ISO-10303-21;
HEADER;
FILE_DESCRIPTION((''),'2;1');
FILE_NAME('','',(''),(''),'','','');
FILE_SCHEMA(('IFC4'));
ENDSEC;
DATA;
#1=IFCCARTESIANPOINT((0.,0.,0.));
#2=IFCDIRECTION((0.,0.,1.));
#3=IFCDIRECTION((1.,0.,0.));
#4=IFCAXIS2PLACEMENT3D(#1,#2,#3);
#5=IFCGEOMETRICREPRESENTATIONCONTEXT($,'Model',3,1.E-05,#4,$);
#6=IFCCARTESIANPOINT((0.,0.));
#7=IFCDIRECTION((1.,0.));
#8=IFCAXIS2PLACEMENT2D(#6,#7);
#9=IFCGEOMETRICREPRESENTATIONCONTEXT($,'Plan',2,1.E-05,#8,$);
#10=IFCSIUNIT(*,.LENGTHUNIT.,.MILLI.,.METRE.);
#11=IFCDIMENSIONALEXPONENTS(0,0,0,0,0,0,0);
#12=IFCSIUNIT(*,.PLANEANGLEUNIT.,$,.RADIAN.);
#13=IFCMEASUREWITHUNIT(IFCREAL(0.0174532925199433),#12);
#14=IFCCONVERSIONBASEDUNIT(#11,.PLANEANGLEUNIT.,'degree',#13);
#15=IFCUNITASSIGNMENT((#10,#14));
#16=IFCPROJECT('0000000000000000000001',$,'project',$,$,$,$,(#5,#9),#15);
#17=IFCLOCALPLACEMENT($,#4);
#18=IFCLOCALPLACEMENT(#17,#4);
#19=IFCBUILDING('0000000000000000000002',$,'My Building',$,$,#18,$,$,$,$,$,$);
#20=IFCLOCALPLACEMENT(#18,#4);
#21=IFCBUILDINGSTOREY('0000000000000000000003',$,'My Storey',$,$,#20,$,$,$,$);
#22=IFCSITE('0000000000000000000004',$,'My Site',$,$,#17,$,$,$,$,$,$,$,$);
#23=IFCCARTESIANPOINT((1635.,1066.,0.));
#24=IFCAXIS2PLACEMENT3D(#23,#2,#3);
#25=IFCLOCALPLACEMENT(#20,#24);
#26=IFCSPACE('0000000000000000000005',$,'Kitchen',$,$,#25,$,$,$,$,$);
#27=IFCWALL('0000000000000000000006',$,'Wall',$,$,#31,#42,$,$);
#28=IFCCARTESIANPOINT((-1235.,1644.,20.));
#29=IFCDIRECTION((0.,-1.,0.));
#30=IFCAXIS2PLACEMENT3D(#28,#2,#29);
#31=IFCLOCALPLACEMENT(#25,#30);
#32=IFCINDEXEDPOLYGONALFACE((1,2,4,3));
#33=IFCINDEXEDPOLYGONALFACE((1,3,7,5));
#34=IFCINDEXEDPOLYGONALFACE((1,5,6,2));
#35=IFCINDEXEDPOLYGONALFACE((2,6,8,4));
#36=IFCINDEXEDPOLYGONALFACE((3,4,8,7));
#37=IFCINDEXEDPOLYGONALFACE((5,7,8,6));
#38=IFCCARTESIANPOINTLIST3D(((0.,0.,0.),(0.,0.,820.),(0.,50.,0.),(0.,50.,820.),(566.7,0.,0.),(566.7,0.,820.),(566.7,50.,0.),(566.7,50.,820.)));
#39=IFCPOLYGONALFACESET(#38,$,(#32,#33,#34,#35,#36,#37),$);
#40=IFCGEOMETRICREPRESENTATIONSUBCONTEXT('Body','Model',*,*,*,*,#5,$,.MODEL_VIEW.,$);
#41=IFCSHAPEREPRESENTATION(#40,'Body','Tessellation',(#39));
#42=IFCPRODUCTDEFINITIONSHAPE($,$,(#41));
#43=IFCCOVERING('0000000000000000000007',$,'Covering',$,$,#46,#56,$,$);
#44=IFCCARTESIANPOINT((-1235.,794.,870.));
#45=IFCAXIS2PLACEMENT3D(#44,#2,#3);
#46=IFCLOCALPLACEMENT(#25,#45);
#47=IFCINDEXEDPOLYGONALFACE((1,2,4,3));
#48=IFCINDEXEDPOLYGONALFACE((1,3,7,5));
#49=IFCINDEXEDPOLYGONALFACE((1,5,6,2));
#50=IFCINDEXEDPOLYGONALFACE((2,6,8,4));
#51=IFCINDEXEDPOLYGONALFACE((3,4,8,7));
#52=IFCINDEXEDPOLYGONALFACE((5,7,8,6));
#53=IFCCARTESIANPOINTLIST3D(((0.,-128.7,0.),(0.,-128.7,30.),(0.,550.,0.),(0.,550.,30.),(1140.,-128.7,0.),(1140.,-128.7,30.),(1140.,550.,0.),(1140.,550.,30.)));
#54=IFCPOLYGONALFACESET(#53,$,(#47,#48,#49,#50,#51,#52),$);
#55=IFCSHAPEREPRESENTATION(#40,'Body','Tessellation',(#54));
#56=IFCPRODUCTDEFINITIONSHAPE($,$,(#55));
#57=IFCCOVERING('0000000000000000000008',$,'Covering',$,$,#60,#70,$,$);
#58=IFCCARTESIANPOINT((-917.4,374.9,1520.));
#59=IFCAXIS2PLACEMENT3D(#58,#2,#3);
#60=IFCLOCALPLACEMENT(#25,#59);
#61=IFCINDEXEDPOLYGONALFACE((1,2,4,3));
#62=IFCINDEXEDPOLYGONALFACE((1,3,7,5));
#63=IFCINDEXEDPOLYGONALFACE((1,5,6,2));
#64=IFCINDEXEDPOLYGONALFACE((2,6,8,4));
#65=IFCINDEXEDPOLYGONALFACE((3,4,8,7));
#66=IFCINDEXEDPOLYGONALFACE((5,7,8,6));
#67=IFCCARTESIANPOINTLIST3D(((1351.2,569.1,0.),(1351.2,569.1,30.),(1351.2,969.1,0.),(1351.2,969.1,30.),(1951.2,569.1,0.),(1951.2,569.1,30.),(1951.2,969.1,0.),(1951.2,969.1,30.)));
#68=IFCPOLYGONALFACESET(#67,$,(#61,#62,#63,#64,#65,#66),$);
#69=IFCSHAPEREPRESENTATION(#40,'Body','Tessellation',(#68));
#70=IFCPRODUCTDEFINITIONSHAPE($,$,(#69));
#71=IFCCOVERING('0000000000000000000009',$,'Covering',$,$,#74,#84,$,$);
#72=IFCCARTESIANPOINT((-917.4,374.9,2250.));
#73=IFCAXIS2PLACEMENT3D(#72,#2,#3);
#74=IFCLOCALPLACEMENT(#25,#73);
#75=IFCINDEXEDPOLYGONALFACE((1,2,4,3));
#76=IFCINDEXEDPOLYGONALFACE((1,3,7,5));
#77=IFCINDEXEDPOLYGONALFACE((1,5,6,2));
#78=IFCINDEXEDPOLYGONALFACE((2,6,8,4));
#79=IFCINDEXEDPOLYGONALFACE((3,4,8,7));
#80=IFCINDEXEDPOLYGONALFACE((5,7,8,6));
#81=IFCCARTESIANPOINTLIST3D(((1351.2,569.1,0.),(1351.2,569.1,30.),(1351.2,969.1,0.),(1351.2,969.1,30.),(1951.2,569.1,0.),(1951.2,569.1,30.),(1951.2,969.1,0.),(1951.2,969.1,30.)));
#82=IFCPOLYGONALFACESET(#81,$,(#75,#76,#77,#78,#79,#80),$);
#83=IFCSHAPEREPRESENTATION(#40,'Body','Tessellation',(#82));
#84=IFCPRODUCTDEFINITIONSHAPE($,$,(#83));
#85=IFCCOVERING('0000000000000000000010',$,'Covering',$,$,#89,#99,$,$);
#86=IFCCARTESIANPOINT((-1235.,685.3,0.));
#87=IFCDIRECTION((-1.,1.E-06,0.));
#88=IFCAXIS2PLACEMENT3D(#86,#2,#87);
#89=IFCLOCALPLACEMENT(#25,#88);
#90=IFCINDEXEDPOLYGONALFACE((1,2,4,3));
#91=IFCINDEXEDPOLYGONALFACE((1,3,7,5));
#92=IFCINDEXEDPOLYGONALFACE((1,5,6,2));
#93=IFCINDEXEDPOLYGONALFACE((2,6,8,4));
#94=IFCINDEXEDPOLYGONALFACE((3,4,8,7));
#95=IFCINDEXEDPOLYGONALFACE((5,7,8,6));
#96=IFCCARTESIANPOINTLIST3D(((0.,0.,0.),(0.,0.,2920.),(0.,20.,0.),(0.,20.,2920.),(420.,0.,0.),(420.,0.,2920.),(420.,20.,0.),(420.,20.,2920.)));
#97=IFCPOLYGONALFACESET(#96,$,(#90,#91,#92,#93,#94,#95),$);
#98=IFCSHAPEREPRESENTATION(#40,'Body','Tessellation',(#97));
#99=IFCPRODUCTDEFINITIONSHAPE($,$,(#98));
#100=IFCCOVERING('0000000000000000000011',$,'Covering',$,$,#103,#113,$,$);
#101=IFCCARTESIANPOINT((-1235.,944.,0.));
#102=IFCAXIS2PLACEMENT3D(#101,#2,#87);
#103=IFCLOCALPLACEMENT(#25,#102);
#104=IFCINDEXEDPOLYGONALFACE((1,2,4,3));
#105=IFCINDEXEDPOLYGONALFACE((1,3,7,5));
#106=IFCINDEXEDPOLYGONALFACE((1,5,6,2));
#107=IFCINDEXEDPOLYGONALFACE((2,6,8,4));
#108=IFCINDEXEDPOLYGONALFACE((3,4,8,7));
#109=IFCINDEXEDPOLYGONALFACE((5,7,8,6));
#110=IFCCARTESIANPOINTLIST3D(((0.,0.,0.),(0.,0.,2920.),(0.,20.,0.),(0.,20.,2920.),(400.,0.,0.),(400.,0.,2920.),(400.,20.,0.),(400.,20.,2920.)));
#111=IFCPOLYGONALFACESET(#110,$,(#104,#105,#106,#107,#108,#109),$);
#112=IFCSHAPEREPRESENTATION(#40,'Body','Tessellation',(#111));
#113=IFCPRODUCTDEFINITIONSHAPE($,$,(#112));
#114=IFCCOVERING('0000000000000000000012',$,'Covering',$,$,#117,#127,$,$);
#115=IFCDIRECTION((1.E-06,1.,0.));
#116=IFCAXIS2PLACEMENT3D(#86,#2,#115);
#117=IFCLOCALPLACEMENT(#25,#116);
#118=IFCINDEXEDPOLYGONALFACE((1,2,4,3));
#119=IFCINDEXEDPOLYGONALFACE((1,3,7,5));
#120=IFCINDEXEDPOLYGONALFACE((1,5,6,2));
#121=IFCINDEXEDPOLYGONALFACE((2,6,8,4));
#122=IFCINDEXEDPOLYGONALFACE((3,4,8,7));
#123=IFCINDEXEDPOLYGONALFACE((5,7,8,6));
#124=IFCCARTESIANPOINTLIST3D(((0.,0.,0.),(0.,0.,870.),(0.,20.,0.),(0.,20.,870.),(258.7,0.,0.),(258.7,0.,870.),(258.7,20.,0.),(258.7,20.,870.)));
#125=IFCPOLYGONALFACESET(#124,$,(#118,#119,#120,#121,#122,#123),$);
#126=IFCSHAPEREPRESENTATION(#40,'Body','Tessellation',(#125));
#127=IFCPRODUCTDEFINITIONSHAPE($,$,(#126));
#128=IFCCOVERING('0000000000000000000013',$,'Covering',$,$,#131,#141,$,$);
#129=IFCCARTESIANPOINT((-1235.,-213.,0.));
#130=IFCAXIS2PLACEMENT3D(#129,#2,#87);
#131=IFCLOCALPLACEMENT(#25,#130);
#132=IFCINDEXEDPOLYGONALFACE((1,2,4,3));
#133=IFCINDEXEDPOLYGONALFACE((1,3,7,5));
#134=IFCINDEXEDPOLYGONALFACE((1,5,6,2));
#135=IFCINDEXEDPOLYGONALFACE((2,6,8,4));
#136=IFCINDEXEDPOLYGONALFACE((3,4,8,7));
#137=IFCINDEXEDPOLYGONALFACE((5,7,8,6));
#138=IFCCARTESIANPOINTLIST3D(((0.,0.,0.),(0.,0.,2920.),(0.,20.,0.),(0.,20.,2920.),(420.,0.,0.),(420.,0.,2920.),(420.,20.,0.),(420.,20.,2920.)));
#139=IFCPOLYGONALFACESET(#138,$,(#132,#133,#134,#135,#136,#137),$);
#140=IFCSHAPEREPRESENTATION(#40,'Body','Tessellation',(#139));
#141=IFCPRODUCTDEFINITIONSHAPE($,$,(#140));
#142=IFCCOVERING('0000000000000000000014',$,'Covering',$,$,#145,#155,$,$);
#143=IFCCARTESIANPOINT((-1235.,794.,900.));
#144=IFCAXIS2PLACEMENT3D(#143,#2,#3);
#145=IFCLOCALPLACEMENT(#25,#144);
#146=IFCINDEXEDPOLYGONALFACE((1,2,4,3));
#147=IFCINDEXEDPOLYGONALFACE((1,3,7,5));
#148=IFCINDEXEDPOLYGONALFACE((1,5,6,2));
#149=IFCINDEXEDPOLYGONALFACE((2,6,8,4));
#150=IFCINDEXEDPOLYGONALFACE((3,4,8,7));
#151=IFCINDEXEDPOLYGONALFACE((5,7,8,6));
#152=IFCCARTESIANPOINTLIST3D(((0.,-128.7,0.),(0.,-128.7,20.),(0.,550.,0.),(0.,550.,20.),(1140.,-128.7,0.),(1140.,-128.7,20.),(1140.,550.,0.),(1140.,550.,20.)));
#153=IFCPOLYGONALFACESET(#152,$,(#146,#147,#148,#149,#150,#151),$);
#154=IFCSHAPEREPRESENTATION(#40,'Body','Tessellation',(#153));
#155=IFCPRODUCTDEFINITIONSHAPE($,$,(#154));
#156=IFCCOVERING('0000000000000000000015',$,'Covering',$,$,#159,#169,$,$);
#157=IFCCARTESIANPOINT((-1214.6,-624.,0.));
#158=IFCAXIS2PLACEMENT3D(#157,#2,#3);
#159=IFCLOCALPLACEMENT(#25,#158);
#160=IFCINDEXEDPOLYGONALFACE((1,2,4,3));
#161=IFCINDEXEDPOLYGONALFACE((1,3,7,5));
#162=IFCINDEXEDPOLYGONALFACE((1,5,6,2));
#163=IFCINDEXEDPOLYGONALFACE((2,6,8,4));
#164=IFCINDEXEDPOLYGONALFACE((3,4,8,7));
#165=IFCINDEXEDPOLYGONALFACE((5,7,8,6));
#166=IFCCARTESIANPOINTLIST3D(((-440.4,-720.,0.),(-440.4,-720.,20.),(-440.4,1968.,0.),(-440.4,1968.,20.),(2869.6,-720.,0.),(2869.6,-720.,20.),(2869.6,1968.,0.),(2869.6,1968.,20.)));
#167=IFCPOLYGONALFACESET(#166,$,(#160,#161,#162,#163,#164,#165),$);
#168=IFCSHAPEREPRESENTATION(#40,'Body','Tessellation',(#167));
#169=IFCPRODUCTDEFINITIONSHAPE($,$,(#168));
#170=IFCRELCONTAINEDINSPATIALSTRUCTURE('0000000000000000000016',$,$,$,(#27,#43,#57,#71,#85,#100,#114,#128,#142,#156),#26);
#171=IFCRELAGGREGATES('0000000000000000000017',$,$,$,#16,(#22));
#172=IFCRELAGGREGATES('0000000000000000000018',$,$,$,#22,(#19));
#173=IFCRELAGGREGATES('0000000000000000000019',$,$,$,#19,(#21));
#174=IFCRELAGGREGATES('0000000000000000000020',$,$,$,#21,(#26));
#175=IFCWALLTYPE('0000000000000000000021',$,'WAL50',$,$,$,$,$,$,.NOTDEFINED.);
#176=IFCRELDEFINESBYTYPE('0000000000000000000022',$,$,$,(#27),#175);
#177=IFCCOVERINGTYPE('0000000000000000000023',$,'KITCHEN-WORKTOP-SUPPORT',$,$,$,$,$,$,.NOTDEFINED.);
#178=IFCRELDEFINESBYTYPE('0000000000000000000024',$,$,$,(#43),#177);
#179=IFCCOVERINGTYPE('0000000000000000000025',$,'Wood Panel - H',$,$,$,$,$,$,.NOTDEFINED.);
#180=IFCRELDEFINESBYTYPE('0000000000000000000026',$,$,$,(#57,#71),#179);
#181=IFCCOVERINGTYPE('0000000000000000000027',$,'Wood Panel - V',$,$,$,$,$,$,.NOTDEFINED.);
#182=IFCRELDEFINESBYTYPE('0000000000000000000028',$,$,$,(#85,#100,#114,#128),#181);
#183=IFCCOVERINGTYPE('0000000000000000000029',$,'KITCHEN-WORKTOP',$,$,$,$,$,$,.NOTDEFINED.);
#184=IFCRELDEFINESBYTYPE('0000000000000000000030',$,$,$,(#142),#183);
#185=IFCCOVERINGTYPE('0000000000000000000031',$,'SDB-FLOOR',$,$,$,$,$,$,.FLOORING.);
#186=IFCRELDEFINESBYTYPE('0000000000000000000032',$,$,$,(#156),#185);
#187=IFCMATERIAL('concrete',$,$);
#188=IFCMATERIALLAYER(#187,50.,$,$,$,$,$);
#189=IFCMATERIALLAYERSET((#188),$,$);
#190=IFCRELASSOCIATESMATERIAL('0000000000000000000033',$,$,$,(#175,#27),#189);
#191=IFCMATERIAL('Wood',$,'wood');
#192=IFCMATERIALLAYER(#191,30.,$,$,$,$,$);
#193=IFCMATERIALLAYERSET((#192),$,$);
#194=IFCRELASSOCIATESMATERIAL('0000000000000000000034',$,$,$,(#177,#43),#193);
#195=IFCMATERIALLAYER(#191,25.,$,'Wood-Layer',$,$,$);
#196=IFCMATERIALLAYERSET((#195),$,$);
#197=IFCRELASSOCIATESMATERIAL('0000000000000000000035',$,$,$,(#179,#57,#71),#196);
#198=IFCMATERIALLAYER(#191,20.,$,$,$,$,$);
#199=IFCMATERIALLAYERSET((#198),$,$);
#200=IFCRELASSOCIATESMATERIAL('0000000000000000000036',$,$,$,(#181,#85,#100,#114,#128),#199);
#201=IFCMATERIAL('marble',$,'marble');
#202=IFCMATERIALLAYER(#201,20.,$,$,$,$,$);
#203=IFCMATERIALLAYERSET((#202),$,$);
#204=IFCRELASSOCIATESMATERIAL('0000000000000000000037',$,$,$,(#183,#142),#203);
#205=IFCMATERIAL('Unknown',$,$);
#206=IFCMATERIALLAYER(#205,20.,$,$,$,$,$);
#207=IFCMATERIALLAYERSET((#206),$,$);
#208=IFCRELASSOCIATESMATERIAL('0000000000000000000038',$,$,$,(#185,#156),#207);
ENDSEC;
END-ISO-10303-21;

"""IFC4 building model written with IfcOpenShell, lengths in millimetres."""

from ifc_helpers import new_model, entity, si_unit, converted_unit, frame, origin_with_axes, origin_2d_with_axis, place, context, subcontext, project, spatial, line, indexed_curve, outline, extrude, clip, halfspace, material, layer, layer_set, layer_usage, type_object, element, save


model = new_model("IFC4")

# Units and contexts
model_context = context("Model", 3, precision=1e-05, world=origin_with_axes())
plan_context = context("Plan", 2, precision=1e-05, world=origin_2d_with_axis())
body_context = subcontext(model_context, "Body", "Model", "MODEL_VIEW")
ifc_project = project(units=[si_unit("LENGTHUNIT", "METRE", prefix="MILLI"), converted_unit("PLANEANGLEUNIT", "degree", entity("IfcReal", 0.0174532925199433), si_unit("PLANEANGLEUNIT", "RADIAN"), dimensions=[0, 0, 0, 0, 0, 0, 0])], contexts=[model_context, plan_context])

# Site, building, storey
site_placement = place(None, origin_with_axes())
site = spatial("IfcSite", under=ifc_project, at=site_placement, Name="My Site")
building_placement = place(site_placement, origin_with_axes())
building = spatial("IfcBuilding", under=site, at=building_placement, Name="My Building")
storey_placement = place(building_placement, origin_with_axes())
storey = spatial("IfcBuildingStorey", under=building, at=storey_placement, Name="My Storey")

# Shared definitions
ifc_material_1 = material(Name="concrete")

# Shared definitions
space_1_placement = place(storey_placement, frame((1635.0, 1066.0, 0.0), z_axis=(0.0, 0.0, 1.0), x_axis=(1.0, 0.0, 0.0)))
space_1 = spatial("IfcSpace", under=storey, at=space_1_placement, Name="Kitchen")

# Wall
ifc_layer_1 = layer(ifc_material_1, 50.0)
ifc_layer_set_1 = layer_set([ifc_layer_1])
ifc_layer_usage_1 = layer_usage(ifc_layer_set_1, "AXIS2", "POSITIVE", 0.0)
wall_type_1 = type_object("IfcWallType", Name="WAL50", PredefinedType="NOTDEFINED", material=ifc_layer_set_1)
wall_1_placement = place(space_1_placement, frame((-1235.0, 1644.0, 20.0), z_axis=(0.0, 0.0, 1.0), x_axis=(0.0, -1.0, 0.0)))
element("IfcWall", 1, at=wall_1_placement, inside=space_1, type_object=wall_type_1, material=ifc_layer_usage_1, Name="Wall", context=body_context, shape_type="Clipping", body=[
    clip(extrude(outline(indexed_curve([(0.0, 0.0), (0.0, 50.0), (566.7, 50.0), (566.7, 0.0), (0.0, 0.0)], self_intersect=False)), origin_with_axes(), (0.0, 0.0, 1.0), 820.0), halfspace(frame((0.0, 0.0, 820.0), z_axis=(0.0, 0.0, 1.0), x_axis=(-1.0, 0.0, 0.0)), False)),
])

# Coverings
ifc_material_2 = material(Name="marble", Category="marble")
ifc_material_3 = material(Name="Wood", Category="wood")
ifc_layer_2 = layer(ifc_material_3, 30.0)
ifc_layer_set_2 = layer_set([ifc_layer_2])
ifc_layer_usage_2 = layer_usage(ifc_layer_set_2, "AXIS3", "POSITIVE", 0.0)
covering_type_1 = type_object("IfcCoveringType", Name="KITCHEN-WORKTOP-SUPPORT", PredefinedType="NOTDEFINED", material=ifc_layer_set_2)
covering_1_placement = place(space_1_placement, frame((-1235.0, 794.0, 870.0), z_axis=(0.0, 0.0, 1.0), x_axis=(1.0, 0.0, 0.0)))
element("IfcCovering", 2, at=covering_1_placement, inside=space_1, type_object=covering_type_1, material=ifc_layer_usage_2, Name="Covering", context=body_context, shape_type="SweptSolid", body=[
    extrude(outline(indexed_curve([(1140.0, -128.7), (1140.0, 550.0), (0.0, 550.0), (0.0, -128.7)], segments=[line(4, 1), line(1, 2), line(2, 3), line(3, 4)], self_intersect=False)), None, (0.0, 0.0, 1.0), 30.0),
])
ifc_layer_3 = layer(ifc_material_3, 25.0, Name="Wood-Layer")
ifc_layer_set_3 = layer_set([ifc_layer_3])
ifc_layer_usage_3 = layer_usage(ifc_layer_set_3, "AXIS3", "POSITIVE", 0.0)
covering_type_2 = type_object("IfcCoveringType", Name="Wood Panel - H", PredefinedType="NOTDEFINED", material=ifc_layer_set_3)
covering_2_placement = place(space_1_placement, frame((-917.4, 374.9, 1520.0), z_axis=(0.0, 0.0, 1.0), x_axis=(1.0, 0.0, 0.0)))
element("IfcCovering", 3, at=covering_2_placement, inside=space_1, type_object=covering_type_2, material=ifc_layer_usage_3, Name="Covering", context=body_context, shape_type="SweptSolid", body=[
    extrude(outline(indexed_curve([(1351.2, 569.1), (1951.2, 569.1), (1951.2, 969.1), (1351.2, 969.1)], segments=[line(4, 1), line(1, 2), line(2, 3), line(3, 4)], self_intersect=False)), None, (0.0, 0.0, 1.0), 30.0),
])
ifc_layer_usage_4 = layer_usage(ifc_layer_set_3, "AXIS3", "POSITIVE", 0.0)
covering_3_placement = place(space_1_placement, frame((-917.4, 374.9, 2250.0), z_axis=(0.0, 0.0, 1.0), x_axis=(1.0, 0.0, 0.0)))
element("IfcCovering", 4, at=covering_3_placement, inside=space_1, type_object=covering_type_2, material=ifc_layer_usage_4, Name="Covering", context=body_context, shape_type="SweptSolid", body=[
    extrude(outline(indexed_curve([(1351.2, 569.1), (1951.2, 569.1), (1951.2, 969.1), (1351.2, 969.1)], segments=[line(3, 2), line(2, 1), line(1, 4), line(4, 3)], self_intersect=False)), None, (0.0, 0.0, 1.0), 30.0),
])
ifc_layer_4 = layer(ifc_material_3, 20.0)
ifc_layer_set_4 = layer_set([ifc_layer_4])
ifc_layer_usage_5 = layer_usage(ifc_layer_set_4, "AXIS2", "POSITIVE", 0.0)
covering_type_3 = type_object("IfcCoveringType", Name="Wood Panel - V", PredefinedType="NOTDEFINED", material=ifc_layer_set_4)
covering_4_placement = place(space_1_placement, frame((-1235.0, 685.3, 0.0), z_axis=(0.0, 0.0, 1.0), x_axis=(-1.0, 0.000001, 0.0)))
element("IfcCovering", 5, at=covering_4_placement, inside=space_1, type_object=covering_type_3, material=ifc_layer_usage_5, Name="Covering", context=body_context, shape_type="Clipping", body=[
    clip(extrude(outline(indexed_curve([(0.0, 0.0), (0.0, 20.0), (420.0, 20.0), (420.0, 0.0), (0.0, 0.0)], self_intersect=False)), origin_with_axes(), (0.0, 0.0, 1.0), 2920.0), halfspace(frame((0.0, 0.0, 2920.0), z_axis=(0.0, 0.0, 1.0), x_axis=(-1.0, 0.0, 0.0)), False)),
])
ifc_layer_usage_6 = layer_usage(ifc_layer_set_4, "AXIS2", "POSITIVE", 0.0)
covering_5_placement = place(space_1_placement, frame((-1235.0, 944.0, 0.0), z_axis=(0.0, 0.0, 1.0), x_axis=(-1.0, 0.000001, 0.0)))
element("IfcCovering", 6, at=covering_5_placement, inside=space_1, type_object=covering_type_3, material=ifc_layer_usage_6, Name="Covering", context=body_context, shape_type="Clipping", body=[
    clip(extrude(outline(indexed_curve([(0.0, 0.0), (0.0, 20.0), (400.0, 20.0), (400.0, 0.0), (0.0, 0.0)], self_intersect=False)), origin_with_axes(), (0.0, 0.0, 1.0), 2920.0), halfspace(frame((0.0, 0.0, 2920.0), z_axis=(0.0, 0.0, 1.0), x_axis=(-1.0, 0.0, 0.0)), False)),
])
ifc_layer_usage_7 = layer_usage(ifc_layer_set_4, "AXIS2", "POSITIVE", 0.0)
covering_6_placement = place(space_1_placement, frame((-1235.0, 685.3, 0.0), z_axis=(0.0, 0.0, 1.0), x_axis=(0.000001, 1.0, 0.0)))
element("IfcCovering", 7, at=covering_6_placement, inside=space_1, type_object=covering_type_3, material=ifc_layer_usage_7, Name="Covering", context=body_context, shape_type="Clipping", body=[
    clip(extrude(outline(indexed_curve([(0.0, 0.0), (0.0, 20.0), (258.7, 20.0), (258.7, 0.0), (0.0, 0.0)], self_intersect=False)), origin_with_axes(), (0.0, 0.0, 1.0), 870.0), halfspace(frame((0.0, 0.0, 870.0), z_axis=(0.0, 0.0, 1.0), x_axis=(-1.0, 0.0, 0.0)), False)),
])
ifc_layer_usage_8 = layer_usage(ifc_layer_set_4, "AXIS2", "POSITIVE", 0.0)
covering_7_placement = place(space_1_placement, frame((-1235.0, -213.0, 0.0), z_axis=(0.0, 0.0, 1.0), x_axis=(-1.0, 0.000001, 0.0)))
element("IfcCovering", 8, at=covering_7_placement, inside=space_1, type_object=covering_type_3, material=ifc_layer_usage_8, Name="Covering", context=body_context, shape_type="Clipping", body=[
    clip(extrude(outline(indexed_curve([(0.0, 0.0), (0.0, 20.0), (420.0, 20.0), (420.0, 0.0), (0.0, 0.0)], self_intersect=False)), origin_with_axes(), (0.0, 0.0, 1.0), 2920.0), halfspace(frame((0.0, 0.0, 2920.0), z_axis=(0.0, 0.0, 1.0), x_axis=(-1.0, 0.0, 0.0)), False)),
])
ifc_layer_5 = layer(ifc_material_2, 20.0)
ifc_layer_set_5 = layer_set([ifc_layer_5])
ifc_layer_usage_9 = layer_usage(ifc_layer_set_5, "AXIS3", "POSITIVE", 0.0)
covering_type_4 = type_object("IfcCoveringType", Name="KITCHEN-WORKTOP", PredefinedType="NOTDEFINED", material=ifc_layer_set_5)
covering_8_placement = place(space_1_placement, frame((-1235.0, 794.0, 900.0), z_axis=(0.0, 0.0, 1.0), x_axis=(1.0, 0.0, 0.0)))
element("IfcCovering", 9, at=covering_8_placement, inside=space_1, type_object=covering_type_4, material=ifc_layer_usage_9, Name="Covering", context=body_context, shape_type="SweptSolid", body=[
    extrude(outline(indexed_curve([(1140.0, -128.7), (1140.0, 550.0), (0.0, 550.0), (0.0, -128.7)], segments=[line(3, 2), line(2, 1), line(1, 4), line(4, 3)], self_intersect=False)), None, (0.0, 0.0, 1.0), 20.0),
])
ifc_material_4 = material(Name="Unknown")
ifc_layer_6 = layer(ifc_material_4, 20.0)
ifc_layer_set_6 = layer_set([ifc_layer_6])
ifc_layer_usage_10 = layer_usage(ifc_layer_set_6, "AXIS3", "POSITIVE", 0.0)
covering_type_5 = type_object("IfcCoveringType", Name="SDB-FLOOR", PredefinedType="FLOORING", material=ifc_layer_set_6)
covering_9_placement = place(space_1_placement, frame((-1214.6, -624.0, 0.0), z_axis=(0.0, 0.0, 1.0), x_axis=(1.0, 0.0, 0.0)))
element("IfcCovering", 10, at=covering_9_placement, inside=space_1, type_object=covering_type_5, material=ifc_layer_usage_10, Name="Covering", context=body_context, shape_type="SweptSolid", body=[
    extrude(outline(indexed_curve([(2869.6, 1968.0), (-440.4, 1968.0), (-440.4, -720.0), (2869.6, -720.0)], segments=[line(3, 2), line(2, 1), line(1, 4), line(4, 3)], self_intersect=False)), None, (0.0, 0.0, 1.0), 20.0),
])

save(model, "model.ifc")
